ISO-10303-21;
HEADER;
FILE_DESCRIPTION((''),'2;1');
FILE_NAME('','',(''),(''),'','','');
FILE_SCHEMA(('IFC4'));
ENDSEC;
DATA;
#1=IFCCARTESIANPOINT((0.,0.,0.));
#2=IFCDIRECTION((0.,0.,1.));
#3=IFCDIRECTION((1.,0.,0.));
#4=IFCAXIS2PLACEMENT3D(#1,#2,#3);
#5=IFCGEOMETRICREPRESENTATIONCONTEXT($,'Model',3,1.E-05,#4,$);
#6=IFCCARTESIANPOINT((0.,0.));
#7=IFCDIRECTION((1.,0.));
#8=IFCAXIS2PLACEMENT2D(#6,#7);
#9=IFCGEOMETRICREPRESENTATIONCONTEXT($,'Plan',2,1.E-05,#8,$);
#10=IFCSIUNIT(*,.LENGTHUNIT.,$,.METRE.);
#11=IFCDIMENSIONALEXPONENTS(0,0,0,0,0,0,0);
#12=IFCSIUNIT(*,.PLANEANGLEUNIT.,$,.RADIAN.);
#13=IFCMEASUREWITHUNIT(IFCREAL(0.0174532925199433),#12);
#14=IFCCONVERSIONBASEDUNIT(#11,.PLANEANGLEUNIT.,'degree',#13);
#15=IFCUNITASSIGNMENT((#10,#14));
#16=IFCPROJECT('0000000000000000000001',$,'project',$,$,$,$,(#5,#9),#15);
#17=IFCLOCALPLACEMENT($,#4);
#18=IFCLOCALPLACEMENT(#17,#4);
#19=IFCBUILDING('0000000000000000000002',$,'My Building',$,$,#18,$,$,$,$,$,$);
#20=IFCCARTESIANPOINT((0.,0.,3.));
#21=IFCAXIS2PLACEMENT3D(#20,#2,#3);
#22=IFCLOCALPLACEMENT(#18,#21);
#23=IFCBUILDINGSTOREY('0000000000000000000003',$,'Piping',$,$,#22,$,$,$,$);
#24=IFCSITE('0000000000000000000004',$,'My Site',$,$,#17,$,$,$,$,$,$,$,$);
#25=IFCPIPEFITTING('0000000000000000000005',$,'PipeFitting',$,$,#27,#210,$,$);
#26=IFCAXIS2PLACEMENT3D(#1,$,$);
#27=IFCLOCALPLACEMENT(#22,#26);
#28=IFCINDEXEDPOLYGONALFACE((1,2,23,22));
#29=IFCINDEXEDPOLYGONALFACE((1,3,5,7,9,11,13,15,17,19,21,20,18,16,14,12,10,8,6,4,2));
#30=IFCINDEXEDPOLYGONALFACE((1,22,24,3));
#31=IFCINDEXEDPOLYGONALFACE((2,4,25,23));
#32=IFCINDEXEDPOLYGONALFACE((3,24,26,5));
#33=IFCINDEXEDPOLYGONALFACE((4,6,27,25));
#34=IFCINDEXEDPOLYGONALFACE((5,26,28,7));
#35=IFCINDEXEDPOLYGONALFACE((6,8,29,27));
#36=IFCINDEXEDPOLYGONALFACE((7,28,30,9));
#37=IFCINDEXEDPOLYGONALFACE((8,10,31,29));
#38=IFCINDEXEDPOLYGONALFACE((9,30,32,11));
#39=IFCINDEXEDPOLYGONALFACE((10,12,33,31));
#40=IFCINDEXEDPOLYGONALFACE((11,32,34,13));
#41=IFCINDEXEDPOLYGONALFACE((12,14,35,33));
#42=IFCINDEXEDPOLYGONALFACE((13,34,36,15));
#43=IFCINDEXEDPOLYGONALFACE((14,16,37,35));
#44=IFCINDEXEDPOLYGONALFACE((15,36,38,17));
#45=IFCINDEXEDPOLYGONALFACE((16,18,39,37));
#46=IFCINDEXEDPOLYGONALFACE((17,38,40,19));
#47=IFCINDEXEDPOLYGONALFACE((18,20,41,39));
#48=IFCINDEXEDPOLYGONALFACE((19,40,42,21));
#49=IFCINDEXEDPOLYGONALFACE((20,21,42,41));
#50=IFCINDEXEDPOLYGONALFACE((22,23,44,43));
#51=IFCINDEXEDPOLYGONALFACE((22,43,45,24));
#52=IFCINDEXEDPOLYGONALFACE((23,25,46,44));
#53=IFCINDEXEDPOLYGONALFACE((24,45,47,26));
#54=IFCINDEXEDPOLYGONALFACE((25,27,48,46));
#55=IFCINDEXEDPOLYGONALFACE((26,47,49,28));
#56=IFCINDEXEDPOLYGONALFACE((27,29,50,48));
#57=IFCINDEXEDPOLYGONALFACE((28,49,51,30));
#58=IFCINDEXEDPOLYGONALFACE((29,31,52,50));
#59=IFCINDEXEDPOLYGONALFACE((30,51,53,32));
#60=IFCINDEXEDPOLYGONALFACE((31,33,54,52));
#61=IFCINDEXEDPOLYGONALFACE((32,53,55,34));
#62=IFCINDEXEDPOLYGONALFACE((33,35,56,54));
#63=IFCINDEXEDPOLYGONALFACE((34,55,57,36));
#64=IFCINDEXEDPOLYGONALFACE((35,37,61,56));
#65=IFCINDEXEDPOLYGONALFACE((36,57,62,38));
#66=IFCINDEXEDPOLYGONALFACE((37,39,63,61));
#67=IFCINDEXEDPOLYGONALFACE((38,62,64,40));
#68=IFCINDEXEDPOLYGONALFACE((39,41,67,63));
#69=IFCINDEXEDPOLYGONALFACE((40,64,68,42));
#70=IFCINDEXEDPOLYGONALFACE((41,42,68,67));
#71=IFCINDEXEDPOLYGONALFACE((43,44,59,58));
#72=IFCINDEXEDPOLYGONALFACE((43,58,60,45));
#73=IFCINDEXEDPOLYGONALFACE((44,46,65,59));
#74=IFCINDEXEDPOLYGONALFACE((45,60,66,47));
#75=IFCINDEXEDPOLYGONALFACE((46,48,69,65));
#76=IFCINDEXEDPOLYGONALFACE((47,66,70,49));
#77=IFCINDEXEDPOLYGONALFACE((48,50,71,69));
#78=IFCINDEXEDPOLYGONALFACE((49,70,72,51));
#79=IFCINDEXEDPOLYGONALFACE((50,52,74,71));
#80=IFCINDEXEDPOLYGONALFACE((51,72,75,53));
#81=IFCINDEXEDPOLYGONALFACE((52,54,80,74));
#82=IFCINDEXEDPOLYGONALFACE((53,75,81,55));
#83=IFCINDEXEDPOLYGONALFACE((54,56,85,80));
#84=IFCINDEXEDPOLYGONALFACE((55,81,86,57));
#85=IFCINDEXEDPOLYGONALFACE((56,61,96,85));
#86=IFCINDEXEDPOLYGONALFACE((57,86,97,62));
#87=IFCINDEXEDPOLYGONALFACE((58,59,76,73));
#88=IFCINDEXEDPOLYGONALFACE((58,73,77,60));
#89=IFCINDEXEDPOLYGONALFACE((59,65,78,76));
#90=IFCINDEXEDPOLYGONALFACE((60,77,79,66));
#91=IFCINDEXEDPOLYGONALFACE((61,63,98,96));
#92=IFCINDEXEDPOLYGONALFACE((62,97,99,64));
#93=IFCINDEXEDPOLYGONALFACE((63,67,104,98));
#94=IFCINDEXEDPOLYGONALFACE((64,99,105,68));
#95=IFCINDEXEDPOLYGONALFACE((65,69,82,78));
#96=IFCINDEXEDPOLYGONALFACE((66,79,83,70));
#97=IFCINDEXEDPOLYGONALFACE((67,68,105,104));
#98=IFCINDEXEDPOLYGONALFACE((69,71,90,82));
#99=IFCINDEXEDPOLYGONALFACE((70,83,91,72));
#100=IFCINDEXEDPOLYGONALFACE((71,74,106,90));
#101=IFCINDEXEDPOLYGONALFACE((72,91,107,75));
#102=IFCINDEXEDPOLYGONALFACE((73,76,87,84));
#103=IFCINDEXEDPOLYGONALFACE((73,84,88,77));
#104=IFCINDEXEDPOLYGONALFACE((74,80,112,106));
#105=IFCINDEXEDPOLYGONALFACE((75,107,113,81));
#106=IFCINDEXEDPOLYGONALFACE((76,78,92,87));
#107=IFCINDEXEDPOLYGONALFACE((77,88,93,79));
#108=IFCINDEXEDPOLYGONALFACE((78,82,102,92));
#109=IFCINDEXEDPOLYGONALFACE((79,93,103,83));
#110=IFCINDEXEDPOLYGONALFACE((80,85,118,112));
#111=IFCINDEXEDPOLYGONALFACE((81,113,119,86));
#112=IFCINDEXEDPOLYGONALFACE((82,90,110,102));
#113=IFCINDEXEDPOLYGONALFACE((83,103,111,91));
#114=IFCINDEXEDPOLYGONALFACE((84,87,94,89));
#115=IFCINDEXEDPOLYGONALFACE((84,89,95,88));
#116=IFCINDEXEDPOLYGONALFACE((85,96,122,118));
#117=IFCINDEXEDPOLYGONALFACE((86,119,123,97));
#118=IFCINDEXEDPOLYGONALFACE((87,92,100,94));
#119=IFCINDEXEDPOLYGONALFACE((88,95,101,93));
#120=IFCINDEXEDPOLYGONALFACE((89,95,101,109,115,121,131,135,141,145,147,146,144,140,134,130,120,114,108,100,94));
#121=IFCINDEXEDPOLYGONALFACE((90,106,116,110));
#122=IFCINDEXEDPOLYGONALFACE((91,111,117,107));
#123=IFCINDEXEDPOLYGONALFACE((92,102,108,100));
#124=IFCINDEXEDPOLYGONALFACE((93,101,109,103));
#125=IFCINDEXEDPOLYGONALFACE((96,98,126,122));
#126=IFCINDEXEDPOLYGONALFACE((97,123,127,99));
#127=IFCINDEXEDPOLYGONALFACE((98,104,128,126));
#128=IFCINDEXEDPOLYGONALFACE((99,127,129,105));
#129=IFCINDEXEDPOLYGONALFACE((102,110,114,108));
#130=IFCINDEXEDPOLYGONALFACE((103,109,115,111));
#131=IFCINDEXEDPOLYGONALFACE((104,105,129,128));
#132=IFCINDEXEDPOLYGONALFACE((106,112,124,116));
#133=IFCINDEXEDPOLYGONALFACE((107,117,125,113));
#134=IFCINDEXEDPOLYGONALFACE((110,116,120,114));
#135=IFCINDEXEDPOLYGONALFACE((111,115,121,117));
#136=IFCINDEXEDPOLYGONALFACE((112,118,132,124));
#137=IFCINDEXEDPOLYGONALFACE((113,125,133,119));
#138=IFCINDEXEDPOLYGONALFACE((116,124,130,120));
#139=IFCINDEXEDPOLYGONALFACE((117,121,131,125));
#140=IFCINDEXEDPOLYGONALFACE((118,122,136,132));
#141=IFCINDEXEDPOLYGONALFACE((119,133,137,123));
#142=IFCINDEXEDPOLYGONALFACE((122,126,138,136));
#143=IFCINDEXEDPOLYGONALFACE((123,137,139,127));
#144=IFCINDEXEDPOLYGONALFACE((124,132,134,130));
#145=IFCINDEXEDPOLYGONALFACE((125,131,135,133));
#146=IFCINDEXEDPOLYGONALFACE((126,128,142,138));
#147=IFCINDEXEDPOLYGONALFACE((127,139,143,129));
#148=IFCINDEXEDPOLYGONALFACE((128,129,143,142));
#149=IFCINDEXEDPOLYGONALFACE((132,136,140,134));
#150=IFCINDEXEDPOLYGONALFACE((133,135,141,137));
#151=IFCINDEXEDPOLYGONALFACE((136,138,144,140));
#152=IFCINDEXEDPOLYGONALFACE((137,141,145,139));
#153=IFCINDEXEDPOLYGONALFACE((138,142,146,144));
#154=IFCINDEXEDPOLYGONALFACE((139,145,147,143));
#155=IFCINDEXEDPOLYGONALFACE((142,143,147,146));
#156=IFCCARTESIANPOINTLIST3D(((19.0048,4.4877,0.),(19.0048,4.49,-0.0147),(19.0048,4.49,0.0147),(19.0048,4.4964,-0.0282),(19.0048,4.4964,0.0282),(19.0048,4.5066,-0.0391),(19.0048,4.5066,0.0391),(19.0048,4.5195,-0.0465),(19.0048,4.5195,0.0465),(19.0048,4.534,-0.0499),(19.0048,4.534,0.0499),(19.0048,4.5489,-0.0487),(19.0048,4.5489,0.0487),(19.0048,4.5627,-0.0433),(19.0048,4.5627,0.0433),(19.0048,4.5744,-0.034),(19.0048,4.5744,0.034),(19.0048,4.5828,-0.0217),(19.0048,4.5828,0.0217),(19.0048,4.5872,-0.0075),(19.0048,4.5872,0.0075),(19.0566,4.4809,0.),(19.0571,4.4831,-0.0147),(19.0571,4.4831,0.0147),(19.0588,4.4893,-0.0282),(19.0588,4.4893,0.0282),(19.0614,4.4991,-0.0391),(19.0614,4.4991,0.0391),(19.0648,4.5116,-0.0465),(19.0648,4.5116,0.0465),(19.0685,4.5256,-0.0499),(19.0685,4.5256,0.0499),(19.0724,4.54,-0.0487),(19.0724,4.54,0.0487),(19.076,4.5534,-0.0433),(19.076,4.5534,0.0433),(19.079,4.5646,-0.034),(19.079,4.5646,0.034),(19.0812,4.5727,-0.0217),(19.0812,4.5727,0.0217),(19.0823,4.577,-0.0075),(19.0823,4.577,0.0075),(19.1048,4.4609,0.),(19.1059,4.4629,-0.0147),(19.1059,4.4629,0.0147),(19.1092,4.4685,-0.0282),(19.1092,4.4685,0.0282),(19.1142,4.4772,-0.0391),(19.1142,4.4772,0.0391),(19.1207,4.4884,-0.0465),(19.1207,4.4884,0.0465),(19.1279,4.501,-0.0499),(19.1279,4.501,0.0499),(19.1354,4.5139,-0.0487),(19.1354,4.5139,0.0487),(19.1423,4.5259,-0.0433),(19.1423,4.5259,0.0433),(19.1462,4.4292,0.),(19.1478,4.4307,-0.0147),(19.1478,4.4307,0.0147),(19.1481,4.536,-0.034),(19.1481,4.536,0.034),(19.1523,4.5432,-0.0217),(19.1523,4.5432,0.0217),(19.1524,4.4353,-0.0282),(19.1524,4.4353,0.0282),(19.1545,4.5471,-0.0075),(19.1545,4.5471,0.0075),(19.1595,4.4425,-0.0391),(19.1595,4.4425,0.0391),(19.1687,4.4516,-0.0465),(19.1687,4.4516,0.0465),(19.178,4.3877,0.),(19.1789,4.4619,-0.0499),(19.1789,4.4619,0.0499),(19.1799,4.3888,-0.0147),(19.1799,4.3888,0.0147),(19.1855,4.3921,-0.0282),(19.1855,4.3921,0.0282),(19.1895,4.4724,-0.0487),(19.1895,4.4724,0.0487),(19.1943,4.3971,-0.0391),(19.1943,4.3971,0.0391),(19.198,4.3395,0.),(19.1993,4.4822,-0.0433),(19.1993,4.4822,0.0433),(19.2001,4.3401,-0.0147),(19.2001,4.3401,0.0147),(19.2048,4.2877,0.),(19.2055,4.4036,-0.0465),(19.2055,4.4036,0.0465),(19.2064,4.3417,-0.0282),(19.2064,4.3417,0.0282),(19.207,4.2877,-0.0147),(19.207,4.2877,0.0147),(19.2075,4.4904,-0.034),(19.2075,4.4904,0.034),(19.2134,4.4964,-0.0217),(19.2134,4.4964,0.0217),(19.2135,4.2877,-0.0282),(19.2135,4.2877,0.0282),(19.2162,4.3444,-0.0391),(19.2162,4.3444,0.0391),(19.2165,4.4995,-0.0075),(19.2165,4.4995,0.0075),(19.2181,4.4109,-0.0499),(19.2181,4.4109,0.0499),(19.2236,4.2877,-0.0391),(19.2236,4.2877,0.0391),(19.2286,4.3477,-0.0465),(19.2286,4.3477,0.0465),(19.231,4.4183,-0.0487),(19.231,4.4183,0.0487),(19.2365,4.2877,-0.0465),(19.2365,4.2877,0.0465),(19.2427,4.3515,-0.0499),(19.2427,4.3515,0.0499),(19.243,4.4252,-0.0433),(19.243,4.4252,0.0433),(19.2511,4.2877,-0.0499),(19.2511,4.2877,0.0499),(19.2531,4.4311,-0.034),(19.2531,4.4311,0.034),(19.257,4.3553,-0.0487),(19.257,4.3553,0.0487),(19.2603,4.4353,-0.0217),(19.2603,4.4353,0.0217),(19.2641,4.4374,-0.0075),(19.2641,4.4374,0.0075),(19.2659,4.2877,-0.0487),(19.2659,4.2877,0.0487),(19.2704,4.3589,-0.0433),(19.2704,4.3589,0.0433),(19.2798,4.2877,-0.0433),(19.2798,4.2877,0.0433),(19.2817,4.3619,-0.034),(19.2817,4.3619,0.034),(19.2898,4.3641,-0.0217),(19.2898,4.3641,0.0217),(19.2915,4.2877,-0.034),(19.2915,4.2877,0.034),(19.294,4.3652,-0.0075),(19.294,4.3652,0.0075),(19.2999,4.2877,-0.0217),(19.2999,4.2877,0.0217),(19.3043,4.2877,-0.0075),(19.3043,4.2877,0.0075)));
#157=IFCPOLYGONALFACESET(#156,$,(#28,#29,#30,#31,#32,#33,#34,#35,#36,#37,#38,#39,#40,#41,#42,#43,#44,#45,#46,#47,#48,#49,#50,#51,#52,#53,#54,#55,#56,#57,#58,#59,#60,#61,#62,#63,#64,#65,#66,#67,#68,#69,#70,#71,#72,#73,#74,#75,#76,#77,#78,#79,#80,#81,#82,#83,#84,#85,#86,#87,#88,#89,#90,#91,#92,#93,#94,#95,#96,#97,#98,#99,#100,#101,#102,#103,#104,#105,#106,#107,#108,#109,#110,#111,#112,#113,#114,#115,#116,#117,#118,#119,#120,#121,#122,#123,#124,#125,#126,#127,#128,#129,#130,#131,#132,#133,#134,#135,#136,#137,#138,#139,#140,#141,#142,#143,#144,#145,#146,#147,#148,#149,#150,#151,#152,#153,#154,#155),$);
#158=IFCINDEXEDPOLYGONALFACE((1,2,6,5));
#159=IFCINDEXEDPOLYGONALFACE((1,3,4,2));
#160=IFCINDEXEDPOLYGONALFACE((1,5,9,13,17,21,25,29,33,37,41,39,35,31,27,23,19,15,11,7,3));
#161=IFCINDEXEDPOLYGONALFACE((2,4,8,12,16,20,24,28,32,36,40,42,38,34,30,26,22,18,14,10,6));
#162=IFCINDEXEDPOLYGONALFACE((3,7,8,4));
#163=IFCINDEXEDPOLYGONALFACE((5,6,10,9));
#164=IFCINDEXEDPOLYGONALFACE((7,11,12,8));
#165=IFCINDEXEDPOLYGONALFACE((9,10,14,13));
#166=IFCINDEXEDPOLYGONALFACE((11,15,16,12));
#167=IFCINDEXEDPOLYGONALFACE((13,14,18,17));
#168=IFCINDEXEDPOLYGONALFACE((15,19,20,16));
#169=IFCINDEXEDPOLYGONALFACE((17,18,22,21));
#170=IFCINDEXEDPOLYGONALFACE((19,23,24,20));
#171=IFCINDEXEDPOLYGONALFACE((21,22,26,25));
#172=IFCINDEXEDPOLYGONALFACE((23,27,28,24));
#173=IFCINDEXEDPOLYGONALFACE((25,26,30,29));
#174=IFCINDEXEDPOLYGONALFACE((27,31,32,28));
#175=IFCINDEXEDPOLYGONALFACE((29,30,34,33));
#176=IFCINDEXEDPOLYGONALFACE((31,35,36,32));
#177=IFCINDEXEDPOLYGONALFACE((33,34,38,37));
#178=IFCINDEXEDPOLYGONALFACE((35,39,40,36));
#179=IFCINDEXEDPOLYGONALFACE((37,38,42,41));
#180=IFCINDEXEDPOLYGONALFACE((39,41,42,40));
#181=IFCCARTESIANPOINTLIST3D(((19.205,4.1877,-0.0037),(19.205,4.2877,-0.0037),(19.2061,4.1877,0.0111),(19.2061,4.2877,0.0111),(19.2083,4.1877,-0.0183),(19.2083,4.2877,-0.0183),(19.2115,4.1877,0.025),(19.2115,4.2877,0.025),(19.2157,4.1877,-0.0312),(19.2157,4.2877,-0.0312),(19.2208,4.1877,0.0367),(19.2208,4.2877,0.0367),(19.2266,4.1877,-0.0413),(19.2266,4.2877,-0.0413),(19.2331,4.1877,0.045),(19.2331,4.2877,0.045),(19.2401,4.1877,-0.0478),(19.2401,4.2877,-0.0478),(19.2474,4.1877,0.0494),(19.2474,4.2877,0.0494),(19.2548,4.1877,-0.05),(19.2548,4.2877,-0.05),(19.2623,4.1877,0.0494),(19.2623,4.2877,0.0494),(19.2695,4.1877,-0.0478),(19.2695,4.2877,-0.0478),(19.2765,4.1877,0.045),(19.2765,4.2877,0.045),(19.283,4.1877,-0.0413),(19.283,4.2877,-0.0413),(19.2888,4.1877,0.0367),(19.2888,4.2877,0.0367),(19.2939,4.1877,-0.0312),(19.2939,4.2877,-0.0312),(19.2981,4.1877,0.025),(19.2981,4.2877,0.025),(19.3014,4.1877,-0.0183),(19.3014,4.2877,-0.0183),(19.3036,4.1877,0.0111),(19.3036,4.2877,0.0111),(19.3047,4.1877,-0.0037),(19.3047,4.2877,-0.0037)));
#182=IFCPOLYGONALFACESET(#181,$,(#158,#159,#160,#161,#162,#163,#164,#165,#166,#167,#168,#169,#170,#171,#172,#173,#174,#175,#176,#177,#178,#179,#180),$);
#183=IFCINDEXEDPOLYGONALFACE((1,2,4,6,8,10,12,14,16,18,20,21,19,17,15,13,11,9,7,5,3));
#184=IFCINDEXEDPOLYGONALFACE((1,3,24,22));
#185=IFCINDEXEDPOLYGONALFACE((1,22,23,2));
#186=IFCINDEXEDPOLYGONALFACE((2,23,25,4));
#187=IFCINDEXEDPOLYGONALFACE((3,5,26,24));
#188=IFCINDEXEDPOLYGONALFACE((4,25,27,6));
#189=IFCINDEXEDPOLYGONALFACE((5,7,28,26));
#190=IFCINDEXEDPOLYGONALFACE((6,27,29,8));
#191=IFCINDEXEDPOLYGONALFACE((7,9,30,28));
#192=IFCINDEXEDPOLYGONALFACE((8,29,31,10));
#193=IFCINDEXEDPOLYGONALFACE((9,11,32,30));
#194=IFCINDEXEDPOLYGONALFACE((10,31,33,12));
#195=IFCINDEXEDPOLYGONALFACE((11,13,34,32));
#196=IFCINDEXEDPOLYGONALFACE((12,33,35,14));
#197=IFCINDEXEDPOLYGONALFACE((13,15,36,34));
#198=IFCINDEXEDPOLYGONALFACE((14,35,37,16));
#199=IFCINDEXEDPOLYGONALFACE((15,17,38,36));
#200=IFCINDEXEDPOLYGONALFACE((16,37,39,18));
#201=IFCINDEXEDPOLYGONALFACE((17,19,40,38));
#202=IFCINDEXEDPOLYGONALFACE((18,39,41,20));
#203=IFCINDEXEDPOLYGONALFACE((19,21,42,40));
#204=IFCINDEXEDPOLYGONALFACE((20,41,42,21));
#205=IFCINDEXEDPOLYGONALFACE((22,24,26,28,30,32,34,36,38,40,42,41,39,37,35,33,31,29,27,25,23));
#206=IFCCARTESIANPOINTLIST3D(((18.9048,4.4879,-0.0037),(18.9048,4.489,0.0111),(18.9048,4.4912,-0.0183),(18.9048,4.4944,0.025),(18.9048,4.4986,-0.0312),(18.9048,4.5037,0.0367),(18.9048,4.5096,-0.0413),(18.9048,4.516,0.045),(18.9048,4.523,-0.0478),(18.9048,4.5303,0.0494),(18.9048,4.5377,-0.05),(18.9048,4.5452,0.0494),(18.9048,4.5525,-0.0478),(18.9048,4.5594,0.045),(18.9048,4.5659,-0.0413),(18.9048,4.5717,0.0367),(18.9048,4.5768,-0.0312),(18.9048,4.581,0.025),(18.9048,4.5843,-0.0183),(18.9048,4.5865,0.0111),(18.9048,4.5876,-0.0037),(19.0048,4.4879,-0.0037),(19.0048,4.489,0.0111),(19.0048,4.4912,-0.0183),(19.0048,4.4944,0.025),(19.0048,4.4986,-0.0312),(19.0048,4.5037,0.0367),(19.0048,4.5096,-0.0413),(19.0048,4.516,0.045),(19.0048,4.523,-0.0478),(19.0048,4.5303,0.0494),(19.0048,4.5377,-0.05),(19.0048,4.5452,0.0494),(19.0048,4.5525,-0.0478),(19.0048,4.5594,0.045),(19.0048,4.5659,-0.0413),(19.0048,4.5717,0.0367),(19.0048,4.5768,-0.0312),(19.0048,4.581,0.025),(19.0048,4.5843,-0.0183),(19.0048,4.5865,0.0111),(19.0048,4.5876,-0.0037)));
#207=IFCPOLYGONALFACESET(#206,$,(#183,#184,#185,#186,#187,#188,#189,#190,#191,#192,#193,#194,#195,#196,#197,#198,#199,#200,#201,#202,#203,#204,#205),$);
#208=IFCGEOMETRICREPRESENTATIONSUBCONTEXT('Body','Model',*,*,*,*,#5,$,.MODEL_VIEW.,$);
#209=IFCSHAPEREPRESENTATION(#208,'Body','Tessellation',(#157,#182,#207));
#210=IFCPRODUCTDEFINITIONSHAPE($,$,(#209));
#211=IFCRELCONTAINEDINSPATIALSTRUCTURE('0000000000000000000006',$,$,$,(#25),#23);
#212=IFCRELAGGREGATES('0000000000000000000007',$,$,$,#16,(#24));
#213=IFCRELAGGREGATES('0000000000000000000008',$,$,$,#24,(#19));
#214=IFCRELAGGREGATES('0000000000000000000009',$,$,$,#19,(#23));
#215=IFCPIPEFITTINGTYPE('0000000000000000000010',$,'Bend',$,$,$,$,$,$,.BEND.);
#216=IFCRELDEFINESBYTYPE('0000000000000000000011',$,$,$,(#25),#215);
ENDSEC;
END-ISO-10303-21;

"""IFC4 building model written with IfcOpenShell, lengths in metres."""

from ifc_helpers import new_model, entity, si_unit, converted_unit, frame, origin_with_axes, origin_2d_with_axis, place, context, subcontext, project, spatial, circle, extrude, source, transform, mapped, type_object, type_shapes, element, save


model = new_model("IFC4")

# Units and contexts
model_context = context("Model", 3, precision=1e-05, world=origin_with_axes())
plan_context = context("Plan", 2, precision=1e-05, world=origin_2d_with_axis())
body_context = subcontext(model_context, "Body", "Model", "MODEL_VIEW")
ifc_project = project(units=[si_unit("LENGTHUNIT", "METRE"), converted_unit("PLANEANGLEUNIT", "degree", entity("IfcReal", 0.0174532925199433), si_unit("PLANEANGLEUNIT", "RADIAN"), dimensions=[0, 0, 0, 0, 0, 0, 0])], contexts=[model_context, plan_context])

# Site, building, storey
site_placement = place(None, origin_with_axes())
site = spatial("IfcSite", under=ifc_project, at=site_placement, Name="My Site")
building_placement = place(site_placement, origin_with_axes())
building = spatial("IfcBuilding", under=site, at=building_placement, Name="My Building")
storey_placement = place(building_placement, frame((0.0, 0.0, 3.0), z_axis=(0.0, 0.0, 1.0), x_axis=(1.0, 0.0, 0.0)))
storey = spatial("IfcBuildingStorey", under=building, at=storey_placement, Name="Piping")

# Shared definitions
pipe_fitting_type = type_object("IfcPipeFittingType", Name="Bend", PredefinedType="BEND")
shared_shape = source(origin_with_axes(), body_context, "Body", "SolidModel", [
    entity("IfcSweptDiskSolid", entity("IfcIndexedPolyCurve", entity("IfcCartesianPointList3D", [[0.0, 0.0, -0.1], [0.0, -0.0732, -0.2768], [0.0, -0.25, -0.35]]), [entity("IfcArcIndex", [1, 2, 3])]), 0.05),
    extrude(circle(Radius=0.05), origin_with_axes(), (0.0, 0.0, -1.0), 0.1),
    extrude(circle(Radius=0.05), frame((0.0, -0.25, -0.35), z_axis=(0.0, -1.0, 0.0), x_axis=(1.0, 0.0, 0.0)), (0.0, 0.0, 1.0), 0.1),
])
type_shapes(pipe_fitting_type, [shared_shape])

# Pipe fitting
for number, where, z_axis, x_axis, name in (
    (1, (19.2548, 4.1877, 0.0), (0.0, -1.0, 0.0), (0.0, 0.0, -1.0), "PipeFitting"),
):
    element("IfcPipeFitting", number, at=place(storey_placement, frame(where, z_axis=z_axis, x_axis=x_axis)), inside=storey, type_object=pipe_fitting_type, Name=name, context=body_context, shape_type="MappedRepresentation", body=[
        mapped(shared_shape, transform((0.0, 0.0, 0.0), x_axis=(1.0, 0.0, 0.0), y_axis=(0.0, 1.0, 0.0), z_axis=(0.0, 0.0, 1.0), scale=1.0)),
    ])

save(model, "model.ifc")
